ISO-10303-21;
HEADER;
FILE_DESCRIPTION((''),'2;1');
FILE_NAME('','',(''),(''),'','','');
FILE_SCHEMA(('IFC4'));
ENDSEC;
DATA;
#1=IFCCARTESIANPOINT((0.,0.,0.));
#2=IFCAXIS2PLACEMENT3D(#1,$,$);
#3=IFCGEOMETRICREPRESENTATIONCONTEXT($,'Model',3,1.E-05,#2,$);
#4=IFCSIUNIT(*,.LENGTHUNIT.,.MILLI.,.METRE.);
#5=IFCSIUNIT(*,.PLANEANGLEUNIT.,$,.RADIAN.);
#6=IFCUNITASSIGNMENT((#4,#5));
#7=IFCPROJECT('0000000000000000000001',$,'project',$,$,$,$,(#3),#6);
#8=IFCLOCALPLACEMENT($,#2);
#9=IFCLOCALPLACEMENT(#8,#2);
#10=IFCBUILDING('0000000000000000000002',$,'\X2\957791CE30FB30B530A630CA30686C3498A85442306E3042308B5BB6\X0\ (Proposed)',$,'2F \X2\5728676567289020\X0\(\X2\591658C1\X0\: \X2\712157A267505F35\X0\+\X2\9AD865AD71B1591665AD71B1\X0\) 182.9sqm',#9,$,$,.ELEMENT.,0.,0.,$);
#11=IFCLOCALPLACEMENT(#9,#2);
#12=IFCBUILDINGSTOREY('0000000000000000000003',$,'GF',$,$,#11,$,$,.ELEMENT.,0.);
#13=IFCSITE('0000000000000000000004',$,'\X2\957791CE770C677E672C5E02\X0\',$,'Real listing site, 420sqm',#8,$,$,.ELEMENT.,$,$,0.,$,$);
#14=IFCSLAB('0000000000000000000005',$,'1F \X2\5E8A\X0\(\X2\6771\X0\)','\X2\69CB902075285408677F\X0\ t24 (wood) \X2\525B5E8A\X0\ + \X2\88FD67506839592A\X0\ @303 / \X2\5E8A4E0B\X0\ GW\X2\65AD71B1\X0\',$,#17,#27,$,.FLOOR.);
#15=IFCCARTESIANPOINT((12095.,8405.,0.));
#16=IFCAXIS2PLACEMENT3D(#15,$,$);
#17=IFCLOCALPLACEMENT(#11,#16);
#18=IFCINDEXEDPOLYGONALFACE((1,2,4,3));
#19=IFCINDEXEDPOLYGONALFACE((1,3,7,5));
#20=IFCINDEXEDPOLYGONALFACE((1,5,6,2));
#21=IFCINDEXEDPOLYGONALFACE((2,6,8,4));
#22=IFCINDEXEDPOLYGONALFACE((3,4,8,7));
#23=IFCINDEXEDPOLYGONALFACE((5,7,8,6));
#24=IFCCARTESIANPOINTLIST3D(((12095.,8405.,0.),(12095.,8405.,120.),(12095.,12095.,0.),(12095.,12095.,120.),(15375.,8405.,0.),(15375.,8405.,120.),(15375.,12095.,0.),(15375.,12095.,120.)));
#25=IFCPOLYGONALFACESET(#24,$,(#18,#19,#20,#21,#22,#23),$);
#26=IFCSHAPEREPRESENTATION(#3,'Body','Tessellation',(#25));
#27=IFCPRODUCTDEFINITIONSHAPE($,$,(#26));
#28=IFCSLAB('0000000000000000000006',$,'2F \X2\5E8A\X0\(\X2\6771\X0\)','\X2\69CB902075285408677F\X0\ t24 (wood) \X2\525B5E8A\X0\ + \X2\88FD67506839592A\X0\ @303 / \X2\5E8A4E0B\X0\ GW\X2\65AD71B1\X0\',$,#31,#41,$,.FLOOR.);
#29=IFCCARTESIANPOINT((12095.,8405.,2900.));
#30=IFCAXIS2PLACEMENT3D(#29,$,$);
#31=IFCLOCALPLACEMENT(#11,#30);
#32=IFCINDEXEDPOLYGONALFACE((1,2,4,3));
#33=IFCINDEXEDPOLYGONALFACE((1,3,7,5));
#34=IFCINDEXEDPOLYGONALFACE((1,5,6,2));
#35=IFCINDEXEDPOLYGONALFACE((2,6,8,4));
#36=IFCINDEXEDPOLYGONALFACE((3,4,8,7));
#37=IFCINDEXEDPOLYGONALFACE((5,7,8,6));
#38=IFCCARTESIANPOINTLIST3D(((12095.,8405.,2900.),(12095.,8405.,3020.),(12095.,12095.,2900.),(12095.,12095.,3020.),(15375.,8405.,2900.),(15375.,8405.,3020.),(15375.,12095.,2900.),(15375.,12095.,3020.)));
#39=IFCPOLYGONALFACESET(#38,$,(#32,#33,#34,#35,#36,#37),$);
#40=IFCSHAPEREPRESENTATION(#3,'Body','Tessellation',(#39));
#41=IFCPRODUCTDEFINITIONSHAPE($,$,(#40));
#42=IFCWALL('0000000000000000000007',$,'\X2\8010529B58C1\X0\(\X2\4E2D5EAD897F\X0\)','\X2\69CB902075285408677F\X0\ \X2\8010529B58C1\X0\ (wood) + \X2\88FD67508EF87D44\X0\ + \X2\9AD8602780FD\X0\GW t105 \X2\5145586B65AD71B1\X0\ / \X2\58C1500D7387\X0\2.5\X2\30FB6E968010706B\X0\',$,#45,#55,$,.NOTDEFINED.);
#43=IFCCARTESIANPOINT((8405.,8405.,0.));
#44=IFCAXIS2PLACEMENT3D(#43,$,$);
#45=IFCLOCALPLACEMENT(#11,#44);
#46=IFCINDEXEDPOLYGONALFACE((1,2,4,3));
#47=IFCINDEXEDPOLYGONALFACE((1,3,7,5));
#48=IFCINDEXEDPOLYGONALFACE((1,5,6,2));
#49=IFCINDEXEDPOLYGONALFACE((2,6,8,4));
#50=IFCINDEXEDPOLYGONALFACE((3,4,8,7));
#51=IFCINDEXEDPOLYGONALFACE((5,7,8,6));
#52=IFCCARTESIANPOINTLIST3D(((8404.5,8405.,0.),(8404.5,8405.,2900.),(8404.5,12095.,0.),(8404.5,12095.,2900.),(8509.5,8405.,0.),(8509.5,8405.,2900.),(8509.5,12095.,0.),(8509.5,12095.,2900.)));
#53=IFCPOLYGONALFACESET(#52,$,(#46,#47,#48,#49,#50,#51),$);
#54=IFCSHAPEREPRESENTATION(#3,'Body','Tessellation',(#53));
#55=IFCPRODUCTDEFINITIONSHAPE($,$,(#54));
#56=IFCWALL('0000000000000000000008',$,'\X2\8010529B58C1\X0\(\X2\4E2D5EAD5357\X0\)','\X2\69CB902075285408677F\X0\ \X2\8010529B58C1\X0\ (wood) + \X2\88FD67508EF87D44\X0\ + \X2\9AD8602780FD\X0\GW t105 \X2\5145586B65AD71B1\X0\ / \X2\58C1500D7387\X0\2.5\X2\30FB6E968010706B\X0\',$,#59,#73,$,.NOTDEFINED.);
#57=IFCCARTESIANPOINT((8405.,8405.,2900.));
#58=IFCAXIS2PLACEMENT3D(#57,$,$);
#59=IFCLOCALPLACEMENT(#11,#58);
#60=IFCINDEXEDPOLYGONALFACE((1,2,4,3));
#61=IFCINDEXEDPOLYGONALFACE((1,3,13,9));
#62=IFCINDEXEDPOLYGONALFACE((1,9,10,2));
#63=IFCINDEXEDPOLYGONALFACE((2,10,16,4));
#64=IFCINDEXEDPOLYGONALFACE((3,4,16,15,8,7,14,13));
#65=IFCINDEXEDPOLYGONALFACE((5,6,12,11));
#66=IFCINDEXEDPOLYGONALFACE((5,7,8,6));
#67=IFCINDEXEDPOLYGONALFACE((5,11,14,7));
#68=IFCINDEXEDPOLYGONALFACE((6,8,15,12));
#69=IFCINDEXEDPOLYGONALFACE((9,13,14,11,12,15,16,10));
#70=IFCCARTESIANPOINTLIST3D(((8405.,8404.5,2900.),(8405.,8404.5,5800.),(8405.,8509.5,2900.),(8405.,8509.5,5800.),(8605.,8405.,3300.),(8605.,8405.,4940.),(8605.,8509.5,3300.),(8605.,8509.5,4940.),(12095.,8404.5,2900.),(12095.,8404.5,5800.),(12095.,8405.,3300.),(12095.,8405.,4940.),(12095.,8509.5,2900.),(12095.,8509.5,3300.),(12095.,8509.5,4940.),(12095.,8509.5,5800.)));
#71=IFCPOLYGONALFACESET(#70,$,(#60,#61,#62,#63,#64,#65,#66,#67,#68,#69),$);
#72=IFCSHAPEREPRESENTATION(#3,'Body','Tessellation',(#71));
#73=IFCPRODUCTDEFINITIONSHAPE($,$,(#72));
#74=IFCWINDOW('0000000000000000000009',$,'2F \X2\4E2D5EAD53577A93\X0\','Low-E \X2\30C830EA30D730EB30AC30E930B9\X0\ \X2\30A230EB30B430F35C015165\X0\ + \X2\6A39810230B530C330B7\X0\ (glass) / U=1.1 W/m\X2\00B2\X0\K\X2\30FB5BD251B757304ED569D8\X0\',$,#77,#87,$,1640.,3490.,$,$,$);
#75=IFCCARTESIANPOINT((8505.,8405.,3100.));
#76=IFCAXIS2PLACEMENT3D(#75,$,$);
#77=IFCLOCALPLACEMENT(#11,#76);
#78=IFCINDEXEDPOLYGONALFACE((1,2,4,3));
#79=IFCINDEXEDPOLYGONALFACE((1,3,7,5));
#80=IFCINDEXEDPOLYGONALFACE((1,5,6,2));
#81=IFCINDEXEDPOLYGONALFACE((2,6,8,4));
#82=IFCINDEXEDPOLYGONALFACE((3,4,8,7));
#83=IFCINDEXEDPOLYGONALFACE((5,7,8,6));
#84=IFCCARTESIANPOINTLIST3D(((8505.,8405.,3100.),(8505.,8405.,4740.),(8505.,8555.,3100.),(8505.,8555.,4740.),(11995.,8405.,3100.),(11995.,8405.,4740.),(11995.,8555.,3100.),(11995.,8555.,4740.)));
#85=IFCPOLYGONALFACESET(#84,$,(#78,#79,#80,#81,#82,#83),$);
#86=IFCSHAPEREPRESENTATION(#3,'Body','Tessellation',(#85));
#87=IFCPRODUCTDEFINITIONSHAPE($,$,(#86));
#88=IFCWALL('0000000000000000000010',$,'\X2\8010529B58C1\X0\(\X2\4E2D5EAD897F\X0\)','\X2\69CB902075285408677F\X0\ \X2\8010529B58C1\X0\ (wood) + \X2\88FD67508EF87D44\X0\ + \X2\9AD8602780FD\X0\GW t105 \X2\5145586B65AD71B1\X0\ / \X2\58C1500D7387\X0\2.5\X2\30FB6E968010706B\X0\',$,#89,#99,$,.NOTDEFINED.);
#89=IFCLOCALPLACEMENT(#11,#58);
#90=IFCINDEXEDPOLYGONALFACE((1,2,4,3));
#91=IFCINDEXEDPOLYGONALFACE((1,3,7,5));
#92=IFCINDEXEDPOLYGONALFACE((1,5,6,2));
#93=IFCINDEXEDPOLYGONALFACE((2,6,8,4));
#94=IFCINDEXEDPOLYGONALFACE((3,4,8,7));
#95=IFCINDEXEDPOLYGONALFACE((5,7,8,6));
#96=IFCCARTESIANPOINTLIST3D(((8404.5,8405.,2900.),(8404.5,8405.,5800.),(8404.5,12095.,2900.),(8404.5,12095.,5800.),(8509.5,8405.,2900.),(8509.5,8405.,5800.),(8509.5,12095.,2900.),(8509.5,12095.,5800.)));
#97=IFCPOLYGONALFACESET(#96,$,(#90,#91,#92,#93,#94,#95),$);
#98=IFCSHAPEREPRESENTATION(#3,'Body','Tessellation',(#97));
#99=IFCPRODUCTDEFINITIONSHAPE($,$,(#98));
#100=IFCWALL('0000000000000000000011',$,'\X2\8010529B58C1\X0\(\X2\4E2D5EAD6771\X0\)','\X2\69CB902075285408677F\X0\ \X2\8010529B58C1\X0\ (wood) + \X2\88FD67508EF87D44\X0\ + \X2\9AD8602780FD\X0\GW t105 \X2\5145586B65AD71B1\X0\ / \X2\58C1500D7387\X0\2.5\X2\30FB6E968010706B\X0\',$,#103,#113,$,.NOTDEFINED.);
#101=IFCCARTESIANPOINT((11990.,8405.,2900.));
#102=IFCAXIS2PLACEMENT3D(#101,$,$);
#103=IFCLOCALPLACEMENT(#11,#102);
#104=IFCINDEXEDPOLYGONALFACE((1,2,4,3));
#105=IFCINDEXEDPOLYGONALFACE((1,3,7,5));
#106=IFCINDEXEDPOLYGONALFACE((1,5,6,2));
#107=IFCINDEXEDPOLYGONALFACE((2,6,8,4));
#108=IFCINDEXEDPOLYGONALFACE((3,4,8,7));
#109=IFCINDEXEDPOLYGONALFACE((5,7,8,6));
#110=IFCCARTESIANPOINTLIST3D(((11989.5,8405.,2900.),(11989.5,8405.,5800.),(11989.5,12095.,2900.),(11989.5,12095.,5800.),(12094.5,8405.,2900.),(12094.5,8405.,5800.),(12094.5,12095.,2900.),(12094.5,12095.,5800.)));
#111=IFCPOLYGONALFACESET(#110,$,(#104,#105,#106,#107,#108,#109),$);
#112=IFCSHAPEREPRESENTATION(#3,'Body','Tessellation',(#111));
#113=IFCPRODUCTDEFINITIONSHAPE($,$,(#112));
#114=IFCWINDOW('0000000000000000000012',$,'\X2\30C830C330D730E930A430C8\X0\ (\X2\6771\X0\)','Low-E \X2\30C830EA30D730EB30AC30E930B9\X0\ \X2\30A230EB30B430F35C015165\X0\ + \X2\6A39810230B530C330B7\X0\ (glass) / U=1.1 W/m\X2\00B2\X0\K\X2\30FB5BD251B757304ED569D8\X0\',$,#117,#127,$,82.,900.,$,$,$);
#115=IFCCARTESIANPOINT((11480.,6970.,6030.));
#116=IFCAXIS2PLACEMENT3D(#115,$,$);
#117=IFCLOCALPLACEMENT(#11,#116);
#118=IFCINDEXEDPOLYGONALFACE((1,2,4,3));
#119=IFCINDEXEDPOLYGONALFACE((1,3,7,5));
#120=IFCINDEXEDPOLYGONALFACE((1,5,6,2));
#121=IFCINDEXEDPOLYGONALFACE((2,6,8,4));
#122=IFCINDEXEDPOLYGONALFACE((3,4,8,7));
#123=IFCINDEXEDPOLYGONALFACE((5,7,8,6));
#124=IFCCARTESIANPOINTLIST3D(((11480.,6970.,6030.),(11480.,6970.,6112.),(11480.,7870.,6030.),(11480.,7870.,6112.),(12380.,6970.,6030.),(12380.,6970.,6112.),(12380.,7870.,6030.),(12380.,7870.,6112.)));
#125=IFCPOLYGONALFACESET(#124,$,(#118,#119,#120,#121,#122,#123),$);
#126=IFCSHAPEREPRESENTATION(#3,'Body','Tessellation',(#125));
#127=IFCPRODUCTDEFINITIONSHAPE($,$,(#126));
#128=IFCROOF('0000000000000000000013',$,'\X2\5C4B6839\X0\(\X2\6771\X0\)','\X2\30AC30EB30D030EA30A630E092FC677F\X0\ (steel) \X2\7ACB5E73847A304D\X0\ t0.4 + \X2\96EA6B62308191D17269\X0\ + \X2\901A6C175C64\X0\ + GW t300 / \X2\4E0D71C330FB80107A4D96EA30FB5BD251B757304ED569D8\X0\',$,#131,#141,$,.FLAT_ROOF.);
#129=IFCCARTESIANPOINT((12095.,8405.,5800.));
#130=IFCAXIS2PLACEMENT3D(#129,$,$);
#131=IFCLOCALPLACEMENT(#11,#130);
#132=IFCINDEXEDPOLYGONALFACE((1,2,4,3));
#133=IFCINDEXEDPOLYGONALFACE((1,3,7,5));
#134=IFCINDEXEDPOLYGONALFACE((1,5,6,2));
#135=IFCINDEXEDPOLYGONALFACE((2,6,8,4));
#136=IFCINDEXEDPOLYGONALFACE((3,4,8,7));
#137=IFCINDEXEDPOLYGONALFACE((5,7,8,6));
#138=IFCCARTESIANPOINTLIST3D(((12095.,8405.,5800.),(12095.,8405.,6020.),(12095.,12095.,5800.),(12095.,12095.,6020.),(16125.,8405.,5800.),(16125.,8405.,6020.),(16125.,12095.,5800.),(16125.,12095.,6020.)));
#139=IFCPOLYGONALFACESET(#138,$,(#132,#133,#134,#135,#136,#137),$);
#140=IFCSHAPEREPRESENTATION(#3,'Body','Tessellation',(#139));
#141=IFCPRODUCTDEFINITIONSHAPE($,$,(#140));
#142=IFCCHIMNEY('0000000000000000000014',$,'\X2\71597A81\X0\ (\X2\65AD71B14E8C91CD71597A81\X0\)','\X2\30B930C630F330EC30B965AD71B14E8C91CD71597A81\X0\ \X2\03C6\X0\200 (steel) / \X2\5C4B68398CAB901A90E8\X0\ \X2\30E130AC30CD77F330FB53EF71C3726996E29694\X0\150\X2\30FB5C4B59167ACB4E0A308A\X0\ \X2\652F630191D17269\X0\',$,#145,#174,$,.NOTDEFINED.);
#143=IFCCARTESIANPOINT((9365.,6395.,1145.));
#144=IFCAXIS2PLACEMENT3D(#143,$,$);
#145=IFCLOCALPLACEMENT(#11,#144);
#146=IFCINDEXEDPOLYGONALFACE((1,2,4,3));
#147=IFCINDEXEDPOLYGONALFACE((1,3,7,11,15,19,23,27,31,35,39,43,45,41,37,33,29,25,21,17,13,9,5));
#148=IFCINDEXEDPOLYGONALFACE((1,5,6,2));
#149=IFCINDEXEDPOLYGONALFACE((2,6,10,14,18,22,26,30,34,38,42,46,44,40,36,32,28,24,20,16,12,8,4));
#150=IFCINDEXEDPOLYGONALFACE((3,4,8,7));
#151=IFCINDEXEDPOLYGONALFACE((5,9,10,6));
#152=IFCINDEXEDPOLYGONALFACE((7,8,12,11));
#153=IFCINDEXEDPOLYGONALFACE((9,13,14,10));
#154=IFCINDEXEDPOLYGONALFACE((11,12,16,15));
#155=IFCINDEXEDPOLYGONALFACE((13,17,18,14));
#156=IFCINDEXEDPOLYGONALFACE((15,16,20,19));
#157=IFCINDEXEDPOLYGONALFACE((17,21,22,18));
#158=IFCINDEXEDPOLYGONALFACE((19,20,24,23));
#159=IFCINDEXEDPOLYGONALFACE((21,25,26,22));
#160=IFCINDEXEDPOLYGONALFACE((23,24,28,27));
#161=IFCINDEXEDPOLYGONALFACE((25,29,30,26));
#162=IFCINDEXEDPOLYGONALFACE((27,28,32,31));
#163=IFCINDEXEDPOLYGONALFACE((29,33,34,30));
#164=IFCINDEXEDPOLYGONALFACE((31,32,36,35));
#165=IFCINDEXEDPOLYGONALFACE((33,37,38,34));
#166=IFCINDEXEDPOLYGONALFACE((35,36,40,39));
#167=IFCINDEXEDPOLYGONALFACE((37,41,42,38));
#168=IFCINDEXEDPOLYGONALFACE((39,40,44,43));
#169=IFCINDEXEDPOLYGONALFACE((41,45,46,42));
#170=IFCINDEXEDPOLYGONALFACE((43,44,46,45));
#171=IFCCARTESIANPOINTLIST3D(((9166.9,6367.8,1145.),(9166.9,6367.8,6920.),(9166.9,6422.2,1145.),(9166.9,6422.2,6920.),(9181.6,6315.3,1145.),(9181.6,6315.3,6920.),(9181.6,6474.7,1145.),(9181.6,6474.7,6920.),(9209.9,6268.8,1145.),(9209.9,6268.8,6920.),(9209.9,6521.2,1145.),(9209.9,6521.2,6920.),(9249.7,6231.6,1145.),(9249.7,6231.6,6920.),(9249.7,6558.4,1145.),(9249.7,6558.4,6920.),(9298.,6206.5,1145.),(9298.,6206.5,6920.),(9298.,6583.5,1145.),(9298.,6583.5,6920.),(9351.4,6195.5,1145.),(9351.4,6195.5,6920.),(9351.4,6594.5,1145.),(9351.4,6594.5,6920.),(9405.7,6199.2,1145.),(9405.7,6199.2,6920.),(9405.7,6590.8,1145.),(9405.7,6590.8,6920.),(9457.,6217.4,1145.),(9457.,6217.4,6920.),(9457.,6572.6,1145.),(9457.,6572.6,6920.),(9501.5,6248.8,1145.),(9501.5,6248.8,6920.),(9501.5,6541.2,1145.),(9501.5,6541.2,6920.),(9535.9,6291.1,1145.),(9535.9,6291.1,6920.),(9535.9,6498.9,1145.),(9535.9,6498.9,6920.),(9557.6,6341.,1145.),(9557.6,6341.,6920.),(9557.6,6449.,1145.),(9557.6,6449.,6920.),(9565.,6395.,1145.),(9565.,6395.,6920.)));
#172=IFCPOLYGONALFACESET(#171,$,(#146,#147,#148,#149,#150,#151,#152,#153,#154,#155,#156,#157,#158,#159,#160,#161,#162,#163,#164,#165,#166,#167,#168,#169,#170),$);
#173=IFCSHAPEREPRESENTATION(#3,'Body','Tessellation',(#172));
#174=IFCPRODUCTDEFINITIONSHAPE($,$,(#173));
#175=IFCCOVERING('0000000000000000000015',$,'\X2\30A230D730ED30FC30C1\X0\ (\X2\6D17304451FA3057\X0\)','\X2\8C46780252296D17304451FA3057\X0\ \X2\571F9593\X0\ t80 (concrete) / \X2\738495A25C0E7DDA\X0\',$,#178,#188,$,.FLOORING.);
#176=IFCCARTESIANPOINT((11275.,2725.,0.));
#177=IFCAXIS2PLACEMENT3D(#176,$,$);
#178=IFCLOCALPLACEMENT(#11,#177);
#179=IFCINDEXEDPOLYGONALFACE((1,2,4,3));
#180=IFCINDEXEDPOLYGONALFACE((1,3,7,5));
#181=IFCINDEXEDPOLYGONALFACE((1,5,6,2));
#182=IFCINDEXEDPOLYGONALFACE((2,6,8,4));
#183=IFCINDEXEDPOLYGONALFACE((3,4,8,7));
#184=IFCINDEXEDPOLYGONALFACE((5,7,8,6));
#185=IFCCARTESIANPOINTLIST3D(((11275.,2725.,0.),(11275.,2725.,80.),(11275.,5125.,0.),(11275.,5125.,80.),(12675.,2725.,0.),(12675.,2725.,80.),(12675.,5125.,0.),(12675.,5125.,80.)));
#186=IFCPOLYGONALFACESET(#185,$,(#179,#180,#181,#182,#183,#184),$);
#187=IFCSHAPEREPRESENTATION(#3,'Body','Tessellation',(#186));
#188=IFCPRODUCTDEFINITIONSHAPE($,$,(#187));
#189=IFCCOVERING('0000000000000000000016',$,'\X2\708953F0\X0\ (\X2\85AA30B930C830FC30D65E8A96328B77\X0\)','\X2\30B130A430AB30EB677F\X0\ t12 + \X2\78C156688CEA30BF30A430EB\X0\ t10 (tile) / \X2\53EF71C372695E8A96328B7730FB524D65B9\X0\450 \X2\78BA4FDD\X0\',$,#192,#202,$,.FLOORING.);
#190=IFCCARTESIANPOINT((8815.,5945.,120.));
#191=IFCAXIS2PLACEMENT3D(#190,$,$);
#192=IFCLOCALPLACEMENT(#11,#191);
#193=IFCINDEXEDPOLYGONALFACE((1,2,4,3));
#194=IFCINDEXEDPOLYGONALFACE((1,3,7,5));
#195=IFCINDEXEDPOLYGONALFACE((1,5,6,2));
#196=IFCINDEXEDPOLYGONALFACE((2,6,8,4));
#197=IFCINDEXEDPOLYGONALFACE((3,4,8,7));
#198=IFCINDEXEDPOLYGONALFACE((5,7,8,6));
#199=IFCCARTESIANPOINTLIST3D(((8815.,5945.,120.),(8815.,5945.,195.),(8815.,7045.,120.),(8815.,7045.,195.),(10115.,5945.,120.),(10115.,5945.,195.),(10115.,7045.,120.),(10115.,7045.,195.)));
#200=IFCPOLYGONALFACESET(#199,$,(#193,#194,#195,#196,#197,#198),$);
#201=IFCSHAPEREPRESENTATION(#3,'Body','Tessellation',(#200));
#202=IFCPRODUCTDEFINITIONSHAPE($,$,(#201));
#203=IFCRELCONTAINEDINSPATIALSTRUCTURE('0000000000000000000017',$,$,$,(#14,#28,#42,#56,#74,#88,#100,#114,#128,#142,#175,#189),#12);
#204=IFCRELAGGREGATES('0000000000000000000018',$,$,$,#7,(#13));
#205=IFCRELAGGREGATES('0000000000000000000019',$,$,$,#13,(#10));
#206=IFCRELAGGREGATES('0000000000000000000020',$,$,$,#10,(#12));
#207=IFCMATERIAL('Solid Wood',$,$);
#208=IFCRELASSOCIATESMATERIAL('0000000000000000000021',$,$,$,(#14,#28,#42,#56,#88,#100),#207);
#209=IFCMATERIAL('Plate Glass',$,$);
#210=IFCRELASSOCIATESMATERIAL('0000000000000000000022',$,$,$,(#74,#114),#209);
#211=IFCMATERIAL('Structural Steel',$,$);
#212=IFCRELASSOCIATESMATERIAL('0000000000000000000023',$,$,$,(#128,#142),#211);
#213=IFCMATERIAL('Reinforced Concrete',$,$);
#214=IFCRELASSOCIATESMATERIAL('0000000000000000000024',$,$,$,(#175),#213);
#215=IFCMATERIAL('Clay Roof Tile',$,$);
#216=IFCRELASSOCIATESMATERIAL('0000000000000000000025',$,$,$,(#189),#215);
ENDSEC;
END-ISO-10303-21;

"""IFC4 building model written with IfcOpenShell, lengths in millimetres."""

from ifc_helpers import new_model, si_unit, frame, frame_2d, origin, origin_2d, place, context, project, spatial, rectangle, circle, extrude, material, element, fill, save


model = new_model("IFC4")

# Units and contexts
model_context = context("Model", 3, precision=1e-05, world=origin())
ifc_project = project(units=[si_unit("LENGTHUNIT", "METRE", prefix="MILLI"), si_unit("PLANEANGLEUNIT", "RADIAN")], contexts=[model_context])

# Site, building, storey
site_placement = place(None, origin())
site = spatial("IfcSite", under=ifc_project, at=site_placement, Name="長野県松本市", ObjectType="Real listing site, 420sqm", CompositionType="ELEMENT", RefElevation=0.0)
building_placement = place(site_placement, origin())
building = spatial("IfcBuilding", under=site, at=building_placement, Name="長野・サウナと水風呂のある家 (Proposed)", ObjectType="2F 在来木造(外壁: 無垢材張+高断熱外断熱) 182.9sqm", CompositionType="ELEMENT", ElevationOfRefHeight=0.0, ElevationOfTerrain=0.0)
storey_placement = place(building_placement, origin())
storey = spatial("IfcBuildingStorey", under=building, at=storey_placement, Name="GF", CompositionType="ELEMENT", Elevation=0.0)

# Shared definitions
ifc_material_1 = material(Name="Solid Wood")

# Slabs
slab_1_placement = place(storey_placement, frame((12095.0, 8405.0, 0.0)))
element("IfcSlab", 1, at=slab_1_placement, inside=storey, material=ifc_material_1, Name="1F 床(東)", Description="構造用合板 t24 (wood) 剛床 + 製材根太 @303 / 床下 GW断熱", PredefinedType="FLOOR", context=model_context, shape_type="SweptSolid", body=[
    extrude(rectangle(XDim=3280.0, YDim=3690.0, at=frame_2d((1640.0, 1845.0))), frame((12095.0, 8405.0, 0.0)), (0.0, 0.0, 1.0), 120.0),
])
slab_2_placement = place(storey_placement, frame((12095.0, 8405.0, 2900.0)))
element("IfcSlab", 2, at=slab_2_placement, inside=storey, material=ifc_material_1, Name="2F 床(東)", Description="構造用合板 t24 (wood) 剛床 + 製材根太 @303 / 床下 GW断熱", PredefinedType="FLOOR", context=model_context, shape_type="SweptSolid", body=[
    extrude(rectangle(XDim=3280.0, YDim=3690.0, at=frame_2d((1640.0, 1845.0))), frame((12095.0, 8405.0, 2900.0)), (0.0, 0.0, 1.0), 120.0),
])

# Wall
wall_1_placement = place(storey_placement, frame((8405.0, 8405.0, 0.0)))
element("IfcWall", 3, at=wall_1_placement, inside=storey, material=ifc_material_1, Name="耐力壁(中庭西)", Description="構造用合板 耐力壁 (wood) + 製材軸組 + 高性能GW t105 充填断熱 / 壁倍率2.5・準耐火", PredefinedType="NOTDEFINED", context=model_context, shape_type="SweptSolid", body=[
    extrude(rectangle(XDim=105.0, YDim=3690.0, at=frame_2d((52.0, 1845.0))), frame((8405.0, 8405.0, 0.0)), (0.0, 0.0, 1.0), 2900.0),
])

# Wall, opening, window
wall_2_placement = place(storey_placement, frame((8405.0, 8405.0, 2900.0)))
wall_2 = element("IfcWall", 4, at=wall_2_placement, inside=storey, material=ifc_material_1, Name="耐力壁(中庭南)", Description="構造用合板 耐力壁 (wood) + 製材軸組 + 高性能GW t105 充填断熱 / 壁倍率2.5・準耐火", PredefinedType="NOTDEFINED", context=model_context, shape_type="SweptSolid", body=[
    extrude(rectangle(XDim=3690.0, YDim=105.0, at=frame_2d((1845.0, 52.0))), frame((8405.0, 8405.0, 2900.0)), (0.0, 0.0, 1.0), 2900.0),
])
opening_placement = place(storey_placement, frame((8505.0, 8405.0, 3100.0)))
opening = element("IfcOpeningElement", 5, at=opening_placement, cuts=wall_2, PredefinedType="NOTDEFINED", context=model_context, shape_type="SweptSolid", body=[
    extrude(rectangle(XDim=3490.0, YDim=150.0, at=frame_2d((1745.0, 75.0))), frame((8505.0, 8405.0, 3100.0)), (0.0, 0.0, 1.0), 1640.0),
])
ifc_material_2 = material(Name="Plate Glass")
window_1_placement = place(storey_placement, frame((8505.0, 8405.0, 3100.0)))
window_1 = element("IfcWindow", 6, at=window_1_placement, inside=storey, material=ifc_material_2, Name="2F 中庭南窓", Description="Low-E トリプルガラス アルゴン封入 + 樹脂サッシ (glass) / U=1.1 W/m²K・寒冷地仕様", OverallHeight=1640.0, OverallWidth=3490.0, context=model_context, shape_type="SweptSolid", body=[
    extrude(rectangle(XDim=3490.0, YDim=150.0, at=frame_2d((1745.0, 75.0))), frame((8505.0, 8405.0, 3100.0)), (0.0, 0.0, 1.0), 1640.0),
])
fill(opening, window_1)

# Walls
wall_3_placement = place(storey_placement, frame((8405.0, 8405.0, 2900.0)))
element("IfcWall", 7, at=wall_3_placement, inside=storey, material=ifc_material_1, Name="耐力壁(中庭西)", Description="構造用合板 耐力壁 (wood) + 製材軸組 + 高性能GW t105 充填断熱 / 壁倍率2.5・準耐火", PredefinedType="NOTDEFINED", context=model_context, shape_type="SweptSolid", body=[
    extrude(rectangle(XDim=105.0, YDim=3690.0, at=frame_2d((52.0, 1845.0))), frame((8405.0, 8405.0, 2900.0)), (0.0, 0.0, 1.0), 2900.0),
])
wall_4_placement = place(storey_placement, frame((11990.0, 8405.0, 2900.0)))
element("IfcWall", 8, at=wall_4_placement, inside=storey, material=ifc_material_1, Name="耐力壁(中庭東)", Description="構造用合板 耐力壁 (wood) + 製材軸組 + 高性能GW t105 充填断熱 / 壁倍率2.5・準耐火", PredefinedType="NOTDEFINED", context=model_context, shape_type="SweptSolid", body=[
    extrude(rectangle(XDim=105.0, YDim=3690.0, at=frame_2d((52.0, 1845.0))), frame((11990.0, 8405.0, 2900.0)), (0.0, 0.0, 1.0), 2900.0),
])

# Window
window_2_placement = place(storey_placement, frame((11480.0, 6970.0, 6030.0)))
element("IfcWindow", 9, at=window_2_placement, inside=storey, material=ifc_material_2, Name="トップライト (東)", Description="Low-E トリプルガラス アルゴン封入 + 樹脂サッシ (glass) / U=1.1 W/m²K・寒冷地仕様", OverallHeight=82.0, OverallWidth=900.0, context=model_context, shape_type="SweptSolid", body=[
    extrude(rectangle(XDim=900.0, YDim=900.0, at=frame_2d((450.0, 450.0))), frame((11480.0, 6970.0, 6030.0)), (0.0, 0.0, 1.0), 82.0),
])

# Roof
ifc_material_3 = material(Name="Structural Steel")
roof_placement = place(storey_placement, frame((12095.0, 8405.0, 5800.0)))
element("IfcRoof", 10, at=roof_placement, inside=storey, material=ifc_material_3, Name="屋根(東)", Description="ガルバリウム鋼板 (steel) 立平葺き t0.4 + 雪止め金物 + 通気層 + GW t300 / 不燃・耐積雪・寒冷地仕様", PredefinedType="FLAT_ROOF", context=model_context, shape_type="SweptSolid", body=[
    extrude(rectangle(XDim=4030.0, YDim=3690.0, at=frame_2d((2015.0, 1845.0))), frame((12095.0, 8405.0, 5800.0)), (0.0, 0.0, 1.0), 220.0),
])

# Chimney
chimney_placement = place(storey_placement, frame((9365.0, 6395.0, 1145.0)))
element("IfcChimney", 11, at=chimney_placement, inside=storey, material=ifc_material_3, Name="煙突 (断熱二重煙突)", Description="ステンレス断熱二重煙突 φ200 (steel) / 屋根貫通部 メガネ石・可燃物離隔150・屋外立上り 支持金物", PredefinedType="NOTDEFINED", context=model_context, shape_type="SweptSolid", body=[
    extrude(circle(Radius=200.0, at=origin_2d()), frame((9365.0, 6395.0, 1145.0)), (0.0, 0.0, 1.0), 5775.0),
])

# Coverings
ifc_material_4 = material(Name="Reinforced Concrete")
covering_1_placement = place(storey_placement, frame((11275.0, 2725.0, 0.0)))
element("IfcCovering", 12, at=covering_1_placement, inside=storey, material=ifc_material_4, Name="アプローチ (洗い出し)", Description="豆砂利洗い出し 土間 t80 (concrete) / 玄関導線", PredefinedType="FLOORING", context=model_context, shape_type="SweptSolid", body=[
    extrude(rectangle(XDim=1400.0, YDim=2400.0, at=frame_2d((700.0, 1200.0))), frame((11275.0, 2725.0, 0.0)), (0.0, 0.0, 1.0), 80.0),
])
ifc_material_5 = material(Name="Clay Roof Tile")
covering_2_placement = place(storey_placement, frame((8815.0, 5945.0, 120.0)))
element("IfcCovering", 13, at=covering_2_placement, inside=storey, material=ifc_material_5, Name="炉台 (薪ストーブ床防護)", Description="ケイカル板 t12 + 磁器質タイル t10 (tile) / 可燃物床防護・前方450 確保", PredefinedType="FLOORING", context=model_context, shape_type="SweptSolid", body=[
    extrude(rectangle(XDim=1300.0, YDim=1100.0, at=frame_2d((650.0, 550.0))), frame((8815.0, 5945.0, 120.0)), (0.0, 0.0, 1.0), 75.0),
])

save(model, "model.ifc")
